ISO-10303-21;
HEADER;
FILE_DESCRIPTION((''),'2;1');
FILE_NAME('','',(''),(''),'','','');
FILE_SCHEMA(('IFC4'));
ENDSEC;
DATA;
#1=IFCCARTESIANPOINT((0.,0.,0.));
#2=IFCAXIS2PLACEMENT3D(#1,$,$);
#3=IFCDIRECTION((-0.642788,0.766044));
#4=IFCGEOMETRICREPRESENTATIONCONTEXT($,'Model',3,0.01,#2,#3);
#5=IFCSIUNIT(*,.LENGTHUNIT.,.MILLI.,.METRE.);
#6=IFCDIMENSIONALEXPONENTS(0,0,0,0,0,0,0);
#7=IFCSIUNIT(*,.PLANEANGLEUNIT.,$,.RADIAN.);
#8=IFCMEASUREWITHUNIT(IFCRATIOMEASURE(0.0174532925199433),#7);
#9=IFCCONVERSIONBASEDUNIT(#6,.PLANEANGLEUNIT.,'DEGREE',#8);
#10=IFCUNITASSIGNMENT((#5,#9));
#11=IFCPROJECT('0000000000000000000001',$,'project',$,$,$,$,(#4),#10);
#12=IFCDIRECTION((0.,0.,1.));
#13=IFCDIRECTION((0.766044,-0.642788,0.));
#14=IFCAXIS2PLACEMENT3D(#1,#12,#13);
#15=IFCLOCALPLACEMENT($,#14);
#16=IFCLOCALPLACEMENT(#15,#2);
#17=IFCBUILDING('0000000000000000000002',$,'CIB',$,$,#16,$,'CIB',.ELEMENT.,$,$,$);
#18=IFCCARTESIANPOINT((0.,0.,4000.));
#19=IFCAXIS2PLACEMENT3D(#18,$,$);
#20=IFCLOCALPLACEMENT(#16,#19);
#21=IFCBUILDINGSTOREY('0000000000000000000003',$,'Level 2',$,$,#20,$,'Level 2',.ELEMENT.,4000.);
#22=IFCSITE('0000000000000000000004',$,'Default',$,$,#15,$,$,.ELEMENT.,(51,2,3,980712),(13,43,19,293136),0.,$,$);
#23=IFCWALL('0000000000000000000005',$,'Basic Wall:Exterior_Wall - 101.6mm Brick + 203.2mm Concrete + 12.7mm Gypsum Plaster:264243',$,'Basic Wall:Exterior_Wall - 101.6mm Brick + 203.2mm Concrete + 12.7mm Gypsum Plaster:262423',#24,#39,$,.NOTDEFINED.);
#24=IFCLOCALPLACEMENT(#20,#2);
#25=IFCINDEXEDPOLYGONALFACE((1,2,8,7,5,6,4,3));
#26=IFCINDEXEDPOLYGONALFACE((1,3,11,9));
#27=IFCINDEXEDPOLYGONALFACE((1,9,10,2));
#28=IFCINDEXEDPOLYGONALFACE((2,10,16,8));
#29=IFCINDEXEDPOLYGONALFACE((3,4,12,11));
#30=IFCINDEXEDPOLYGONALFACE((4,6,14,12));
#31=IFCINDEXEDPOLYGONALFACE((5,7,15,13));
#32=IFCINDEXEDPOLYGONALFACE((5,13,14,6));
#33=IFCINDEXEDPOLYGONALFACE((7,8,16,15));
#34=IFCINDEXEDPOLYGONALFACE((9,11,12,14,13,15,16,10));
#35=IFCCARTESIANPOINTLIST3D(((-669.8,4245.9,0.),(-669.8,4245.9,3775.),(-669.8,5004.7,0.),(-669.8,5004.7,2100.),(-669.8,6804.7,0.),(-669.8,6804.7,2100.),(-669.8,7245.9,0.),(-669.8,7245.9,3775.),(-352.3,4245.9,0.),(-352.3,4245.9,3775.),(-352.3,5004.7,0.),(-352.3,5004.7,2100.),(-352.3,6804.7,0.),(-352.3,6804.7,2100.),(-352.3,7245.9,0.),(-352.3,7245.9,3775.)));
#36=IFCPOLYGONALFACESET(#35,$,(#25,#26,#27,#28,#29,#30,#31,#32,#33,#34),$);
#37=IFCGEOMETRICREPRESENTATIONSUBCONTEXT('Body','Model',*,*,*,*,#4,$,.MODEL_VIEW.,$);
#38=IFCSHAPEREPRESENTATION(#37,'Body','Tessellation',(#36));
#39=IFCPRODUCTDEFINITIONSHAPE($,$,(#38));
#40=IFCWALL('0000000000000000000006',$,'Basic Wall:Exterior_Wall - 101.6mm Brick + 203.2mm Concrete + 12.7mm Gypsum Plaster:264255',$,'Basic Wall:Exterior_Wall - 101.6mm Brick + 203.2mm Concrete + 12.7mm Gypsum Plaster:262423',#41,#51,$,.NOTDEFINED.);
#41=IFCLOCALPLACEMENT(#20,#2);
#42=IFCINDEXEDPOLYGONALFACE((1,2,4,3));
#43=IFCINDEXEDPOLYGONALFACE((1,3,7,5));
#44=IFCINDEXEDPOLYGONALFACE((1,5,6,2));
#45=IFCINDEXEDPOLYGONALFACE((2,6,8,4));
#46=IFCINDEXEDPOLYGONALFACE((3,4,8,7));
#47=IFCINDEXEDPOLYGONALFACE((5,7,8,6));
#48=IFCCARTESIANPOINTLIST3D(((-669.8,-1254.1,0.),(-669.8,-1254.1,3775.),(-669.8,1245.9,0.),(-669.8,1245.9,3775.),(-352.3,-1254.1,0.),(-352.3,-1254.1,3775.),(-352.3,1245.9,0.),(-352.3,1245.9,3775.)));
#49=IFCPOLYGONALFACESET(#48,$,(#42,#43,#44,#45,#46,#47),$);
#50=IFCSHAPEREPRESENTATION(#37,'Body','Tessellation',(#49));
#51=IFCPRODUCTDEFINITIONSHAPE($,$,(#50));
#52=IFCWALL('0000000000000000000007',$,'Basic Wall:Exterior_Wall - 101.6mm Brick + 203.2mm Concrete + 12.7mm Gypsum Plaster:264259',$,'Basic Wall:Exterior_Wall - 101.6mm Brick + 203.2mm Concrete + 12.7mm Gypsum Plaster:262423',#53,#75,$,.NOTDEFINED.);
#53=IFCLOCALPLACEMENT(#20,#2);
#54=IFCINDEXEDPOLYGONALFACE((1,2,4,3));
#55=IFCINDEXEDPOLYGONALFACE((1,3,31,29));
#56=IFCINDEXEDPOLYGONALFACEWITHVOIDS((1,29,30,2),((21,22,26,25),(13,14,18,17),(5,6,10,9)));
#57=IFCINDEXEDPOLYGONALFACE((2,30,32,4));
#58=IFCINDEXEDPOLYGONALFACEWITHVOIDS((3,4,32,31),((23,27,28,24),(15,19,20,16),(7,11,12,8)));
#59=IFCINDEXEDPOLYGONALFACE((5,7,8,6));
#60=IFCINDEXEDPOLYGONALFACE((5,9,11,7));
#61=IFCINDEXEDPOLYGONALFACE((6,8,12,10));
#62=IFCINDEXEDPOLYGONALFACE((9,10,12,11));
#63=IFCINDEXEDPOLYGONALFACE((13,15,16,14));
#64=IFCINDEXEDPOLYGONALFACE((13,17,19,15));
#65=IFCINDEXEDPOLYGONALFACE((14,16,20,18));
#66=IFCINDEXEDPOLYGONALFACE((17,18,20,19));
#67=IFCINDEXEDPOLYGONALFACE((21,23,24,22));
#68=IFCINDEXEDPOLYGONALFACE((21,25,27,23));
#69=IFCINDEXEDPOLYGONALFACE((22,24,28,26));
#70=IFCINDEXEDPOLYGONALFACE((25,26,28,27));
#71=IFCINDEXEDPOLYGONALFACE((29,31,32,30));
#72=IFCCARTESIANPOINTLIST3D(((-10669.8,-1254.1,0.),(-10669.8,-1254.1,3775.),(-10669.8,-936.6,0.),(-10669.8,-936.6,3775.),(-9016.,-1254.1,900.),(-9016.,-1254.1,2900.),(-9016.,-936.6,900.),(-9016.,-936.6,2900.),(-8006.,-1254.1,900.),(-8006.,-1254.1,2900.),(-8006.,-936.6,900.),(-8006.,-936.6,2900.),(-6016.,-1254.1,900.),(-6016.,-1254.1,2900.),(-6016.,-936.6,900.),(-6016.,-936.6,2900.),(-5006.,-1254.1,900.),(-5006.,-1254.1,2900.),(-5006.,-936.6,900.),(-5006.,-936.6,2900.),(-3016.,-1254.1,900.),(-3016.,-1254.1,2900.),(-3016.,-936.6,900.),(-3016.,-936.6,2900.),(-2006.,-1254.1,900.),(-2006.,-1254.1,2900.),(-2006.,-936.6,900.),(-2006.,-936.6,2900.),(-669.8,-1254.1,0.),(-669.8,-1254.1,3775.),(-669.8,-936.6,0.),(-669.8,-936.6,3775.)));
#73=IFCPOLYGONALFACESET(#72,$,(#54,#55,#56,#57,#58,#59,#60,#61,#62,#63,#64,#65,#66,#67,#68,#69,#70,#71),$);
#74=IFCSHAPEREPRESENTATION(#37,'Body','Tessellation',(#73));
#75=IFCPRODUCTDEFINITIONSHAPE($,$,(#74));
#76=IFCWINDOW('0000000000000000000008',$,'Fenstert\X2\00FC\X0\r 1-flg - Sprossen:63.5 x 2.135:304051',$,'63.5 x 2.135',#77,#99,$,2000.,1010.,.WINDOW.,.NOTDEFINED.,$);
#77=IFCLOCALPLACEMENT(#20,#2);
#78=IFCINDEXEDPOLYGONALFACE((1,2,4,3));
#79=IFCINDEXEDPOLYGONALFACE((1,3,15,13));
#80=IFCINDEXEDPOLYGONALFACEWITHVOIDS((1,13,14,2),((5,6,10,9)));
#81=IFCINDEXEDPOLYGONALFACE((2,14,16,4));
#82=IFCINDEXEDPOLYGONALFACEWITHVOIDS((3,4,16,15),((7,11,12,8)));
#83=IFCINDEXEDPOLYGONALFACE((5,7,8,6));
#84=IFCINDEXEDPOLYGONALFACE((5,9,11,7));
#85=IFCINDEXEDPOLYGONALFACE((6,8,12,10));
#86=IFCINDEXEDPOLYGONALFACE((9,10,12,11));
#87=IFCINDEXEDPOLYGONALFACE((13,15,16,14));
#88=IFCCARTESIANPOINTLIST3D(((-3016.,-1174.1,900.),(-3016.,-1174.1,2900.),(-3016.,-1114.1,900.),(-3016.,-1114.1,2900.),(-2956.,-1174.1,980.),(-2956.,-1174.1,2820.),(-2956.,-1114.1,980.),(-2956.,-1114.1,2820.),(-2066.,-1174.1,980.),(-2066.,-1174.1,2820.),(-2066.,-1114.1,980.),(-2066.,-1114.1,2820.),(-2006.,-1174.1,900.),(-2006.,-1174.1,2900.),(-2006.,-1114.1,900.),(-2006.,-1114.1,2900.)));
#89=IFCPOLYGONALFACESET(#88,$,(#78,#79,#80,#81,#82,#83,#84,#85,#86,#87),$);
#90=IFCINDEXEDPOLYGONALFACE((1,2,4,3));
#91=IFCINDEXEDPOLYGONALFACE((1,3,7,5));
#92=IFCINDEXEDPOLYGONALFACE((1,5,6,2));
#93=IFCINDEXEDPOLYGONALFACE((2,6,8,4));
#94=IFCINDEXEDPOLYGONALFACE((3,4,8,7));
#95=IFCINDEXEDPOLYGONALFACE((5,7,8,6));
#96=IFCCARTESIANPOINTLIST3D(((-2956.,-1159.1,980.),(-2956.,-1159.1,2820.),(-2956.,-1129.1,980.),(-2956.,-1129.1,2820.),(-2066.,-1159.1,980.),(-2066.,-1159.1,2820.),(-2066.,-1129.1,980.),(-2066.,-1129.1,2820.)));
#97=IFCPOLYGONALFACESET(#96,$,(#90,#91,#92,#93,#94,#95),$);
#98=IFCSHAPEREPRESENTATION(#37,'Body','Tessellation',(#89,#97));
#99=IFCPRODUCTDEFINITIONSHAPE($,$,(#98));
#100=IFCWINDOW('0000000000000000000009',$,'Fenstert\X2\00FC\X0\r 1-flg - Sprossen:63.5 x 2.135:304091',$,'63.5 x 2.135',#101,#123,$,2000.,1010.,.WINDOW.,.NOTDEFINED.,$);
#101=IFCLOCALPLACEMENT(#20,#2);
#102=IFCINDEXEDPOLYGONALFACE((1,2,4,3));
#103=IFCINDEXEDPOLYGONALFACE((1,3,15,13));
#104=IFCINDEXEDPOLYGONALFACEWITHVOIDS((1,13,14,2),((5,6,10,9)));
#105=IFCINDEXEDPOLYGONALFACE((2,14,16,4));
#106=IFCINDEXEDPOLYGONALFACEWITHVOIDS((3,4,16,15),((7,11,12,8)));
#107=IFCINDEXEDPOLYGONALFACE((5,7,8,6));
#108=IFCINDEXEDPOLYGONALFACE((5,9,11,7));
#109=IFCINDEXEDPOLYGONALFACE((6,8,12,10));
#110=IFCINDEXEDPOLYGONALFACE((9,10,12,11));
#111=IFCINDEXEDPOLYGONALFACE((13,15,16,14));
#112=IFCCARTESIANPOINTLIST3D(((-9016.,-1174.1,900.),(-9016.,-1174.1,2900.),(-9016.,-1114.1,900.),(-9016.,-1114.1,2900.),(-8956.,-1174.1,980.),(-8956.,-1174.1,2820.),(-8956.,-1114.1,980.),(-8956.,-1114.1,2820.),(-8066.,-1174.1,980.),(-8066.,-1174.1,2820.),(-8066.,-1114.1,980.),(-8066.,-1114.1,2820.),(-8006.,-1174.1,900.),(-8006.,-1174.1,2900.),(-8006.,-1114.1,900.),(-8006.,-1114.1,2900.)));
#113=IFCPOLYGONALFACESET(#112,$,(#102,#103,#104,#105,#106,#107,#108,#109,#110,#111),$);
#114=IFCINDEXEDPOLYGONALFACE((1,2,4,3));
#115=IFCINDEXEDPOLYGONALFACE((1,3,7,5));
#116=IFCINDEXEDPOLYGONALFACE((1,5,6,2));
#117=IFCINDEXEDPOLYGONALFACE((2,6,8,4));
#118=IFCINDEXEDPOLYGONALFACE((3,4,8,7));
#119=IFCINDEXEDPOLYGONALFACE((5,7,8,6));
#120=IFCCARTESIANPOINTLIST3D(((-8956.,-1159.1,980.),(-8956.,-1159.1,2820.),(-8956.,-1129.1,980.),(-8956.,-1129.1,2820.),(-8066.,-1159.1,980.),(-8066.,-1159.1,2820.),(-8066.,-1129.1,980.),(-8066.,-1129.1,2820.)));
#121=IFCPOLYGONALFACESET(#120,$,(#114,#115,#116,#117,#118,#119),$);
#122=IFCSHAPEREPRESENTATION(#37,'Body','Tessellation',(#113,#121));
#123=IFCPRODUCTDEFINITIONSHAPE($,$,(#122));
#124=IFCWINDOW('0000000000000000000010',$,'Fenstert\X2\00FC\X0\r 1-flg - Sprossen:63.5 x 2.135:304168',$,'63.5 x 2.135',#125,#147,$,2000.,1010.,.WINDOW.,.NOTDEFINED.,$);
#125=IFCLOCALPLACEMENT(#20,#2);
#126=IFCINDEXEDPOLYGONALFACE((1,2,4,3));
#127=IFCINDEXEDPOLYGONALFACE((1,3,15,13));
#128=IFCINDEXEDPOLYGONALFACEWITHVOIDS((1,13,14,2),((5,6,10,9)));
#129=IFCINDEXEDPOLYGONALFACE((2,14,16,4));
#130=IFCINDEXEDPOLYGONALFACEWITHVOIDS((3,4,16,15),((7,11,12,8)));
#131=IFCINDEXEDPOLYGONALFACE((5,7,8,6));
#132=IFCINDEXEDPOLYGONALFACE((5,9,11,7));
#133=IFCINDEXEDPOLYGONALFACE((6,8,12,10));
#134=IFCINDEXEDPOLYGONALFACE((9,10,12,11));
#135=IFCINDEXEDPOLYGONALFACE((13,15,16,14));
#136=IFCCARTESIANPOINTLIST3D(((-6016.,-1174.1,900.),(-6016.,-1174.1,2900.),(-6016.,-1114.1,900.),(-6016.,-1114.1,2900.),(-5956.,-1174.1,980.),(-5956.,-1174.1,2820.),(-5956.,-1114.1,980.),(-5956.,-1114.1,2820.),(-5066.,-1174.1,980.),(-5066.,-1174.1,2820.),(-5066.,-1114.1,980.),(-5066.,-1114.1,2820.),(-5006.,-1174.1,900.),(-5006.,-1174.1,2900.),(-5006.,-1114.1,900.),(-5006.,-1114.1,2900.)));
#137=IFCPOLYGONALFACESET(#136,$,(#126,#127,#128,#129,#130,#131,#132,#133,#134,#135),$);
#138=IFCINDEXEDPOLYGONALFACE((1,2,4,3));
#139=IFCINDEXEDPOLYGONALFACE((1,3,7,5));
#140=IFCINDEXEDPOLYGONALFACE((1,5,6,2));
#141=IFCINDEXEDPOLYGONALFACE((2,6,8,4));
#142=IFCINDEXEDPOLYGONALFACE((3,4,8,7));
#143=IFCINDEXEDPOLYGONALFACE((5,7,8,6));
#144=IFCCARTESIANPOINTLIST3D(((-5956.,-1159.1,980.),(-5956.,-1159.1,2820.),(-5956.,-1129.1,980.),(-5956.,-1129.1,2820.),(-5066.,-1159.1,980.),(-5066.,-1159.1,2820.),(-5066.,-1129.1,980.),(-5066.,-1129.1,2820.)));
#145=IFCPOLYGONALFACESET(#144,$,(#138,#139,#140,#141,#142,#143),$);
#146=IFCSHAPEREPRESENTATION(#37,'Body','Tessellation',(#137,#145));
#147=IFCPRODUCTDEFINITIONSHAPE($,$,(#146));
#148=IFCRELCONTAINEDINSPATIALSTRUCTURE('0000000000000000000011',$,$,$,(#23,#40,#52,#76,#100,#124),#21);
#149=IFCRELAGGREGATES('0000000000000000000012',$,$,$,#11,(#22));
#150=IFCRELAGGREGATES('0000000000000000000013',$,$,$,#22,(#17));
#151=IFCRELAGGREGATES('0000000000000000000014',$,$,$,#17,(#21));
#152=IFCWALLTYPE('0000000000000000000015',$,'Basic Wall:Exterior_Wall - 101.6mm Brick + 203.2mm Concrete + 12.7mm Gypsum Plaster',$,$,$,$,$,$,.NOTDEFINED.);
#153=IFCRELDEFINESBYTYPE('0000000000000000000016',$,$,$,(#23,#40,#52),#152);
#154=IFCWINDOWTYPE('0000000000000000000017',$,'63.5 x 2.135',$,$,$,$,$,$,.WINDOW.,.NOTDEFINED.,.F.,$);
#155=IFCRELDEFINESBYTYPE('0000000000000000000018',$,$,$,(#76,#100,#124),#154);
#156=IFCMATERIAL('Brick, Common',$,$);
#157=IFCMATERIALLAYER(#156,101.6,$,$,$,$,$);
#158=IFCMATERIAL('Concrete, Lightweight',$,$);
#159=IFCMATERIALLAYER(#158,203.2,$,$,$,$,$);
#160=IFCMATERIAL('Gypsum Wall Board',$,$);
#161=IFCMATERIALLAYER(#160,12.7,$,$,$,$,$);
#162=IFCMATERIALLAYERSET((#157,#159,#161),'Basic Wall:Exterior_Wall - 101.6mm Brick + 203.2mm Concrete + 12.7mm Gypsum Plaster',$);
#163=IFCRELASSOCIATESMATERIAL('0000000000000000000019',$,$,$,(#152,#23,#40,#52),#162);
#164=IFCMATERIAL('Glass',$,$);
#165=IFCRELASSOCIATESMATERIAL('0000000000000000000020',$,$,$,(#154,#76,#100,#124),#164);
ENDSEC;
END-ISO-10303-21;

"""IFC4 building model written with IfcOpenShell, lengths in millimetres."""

from ifc_helpers import new_model, entity, si_unit, converted_unit, direction, frame, frame_2d, origin, origin_2d_with_axis, place, context, subcontext, project, spatial, polyline, rectangle, outline, extrude, clip, bounded_halfspace, source, transform, mapped, material, layer, layer_set, layer_usage, type_object, type_shapes, element, fill, save


model = new_model("IFC4")

# Units and contexts
model_context = context("Model", 3, precision=0.01, world=origin(), true_north=direction((-0.642788, 0.766044)))
body_context = subcontext(model_context, "Body", "Model", "MODEL_VIEW")
ifc_project = project(units=[si_unit("LENGTHUNIT", "METRE", prefix="MILLI"), converted_unit("PLANEANGLEUNIT", "DEGREE", entity("IfcRatioMeasure", 0.0174532925199433), si_unit("PLANEANGLEUNIT", "RADIAN"), dimensions=[0, 0, 0, 0, 0, 0, 0])], contexts=[model_context])

# Site, building, storey
site_placement = place(None, frame((0.0, 0.0, 0.0), z_axis=(0.0, 0.0, 1.0), x_axis=(0.766044, -0.642788, 0.0)))
site = spatial("IfcSite", under=ifc_project, at=site_placement, Name="Default", CompositionType="ELEMENT", RefLatitude=(51, 2, 3, 980712), RefLongitude=(13, 43, 19, 293136), RefElevation=0.0)
building_placement = place(site_placement, origin())
building = spatial("IfcBuilding", under=site, at=building_placement, Name="CIB", LongName="CIB", CompositionType="ELEMENT")
storey_placement = place(building_placement, frame((0.0, 0.0, 4000.0)))
storey = spatial("IfcBuildingStorey", under=building, at=storey_placement, Name="Level 2", LongName="Level 2", CompositionType="ELEMENT", Elevation=4000.0)

# Wall, opening
ifc_material_1 = material(Name="Brick, Common")
ifc_layer_1 = layer(ifc_material_1, 101.6)
ifc_material_2 = material(Name="Concrete, Lightweight")
ifc_layer_2 = layer(ifc_material_2, 203.2)
ifc_material_3 = material(Name="Gypsum Wall Board")
ifc_layer_3 = layer(ifc_material_3, 12.7)
ifc_layer_set_1 = layer_set([ifc_layer_1, ifc_layer_2, ifc_layer_3], Name="Basic Wall:Exterior_Wall - 101.6mm Brick + 203.2mm Concrete + 12.7mm Gypsum Plaster")
ifc_layer_usage_1 = layer_usage(ifc_layer_set_1, "AXIS2", "POSITIVE", -158.8)
wall_type_1 = type_object("IfcWallType", Name="Basic Wall:Exterior_Wall - 101.6mm Brick + 203.2mm Concrete + 12.7mm Gypsum Plaster", PredefinedType="NOTDEFINED", material=ifc_layer_set_1)
wall_1_placement = place(storey_placement, frame((-511.0, 4245.9, 0.0), z_axis=(0.0, 0.0, 1.0), x_axis=(0.0, 1.0, 0.0)))
wall_1 = element("IfcWall", 1, at=wall_1_placement, inside=storey, type_object=wall_type_1, material=ifc_layer_usage_1, Name="Basic Wall:Exterior_Wall - 101.6mm Brick + 203.2mm Concrete + 12.7mm Gypsum Plaster:264243", ObjectType="Basic Wall:Exterior_Wall - 101.6mm Brick + 203.2mm Concrete + 12.7mm Gypsum Plaster:262423", PredefinedType="NOTDEFINED", context=body_context, shape_type="Clipping", body=[
    clip(extrude(rectangle(XDim=3000.0, YDim=317.5, at=frame_2d((1500.0, 0.0), x_axis=(-1.0, 0.0))), origin(), (0.0, 0.0, 1.0), 3775.0), bounded_halfspace(frame((3000.0, 158.8, 3775.0), z_axis=(0.0, 0.0, -1.0), x_axis=(1.0, 0.0, 0.0)), True, frame((3000.0, 158.8, 3775.0)), polyline([(0.0, 0.0), (-3000.0, 0.0), (-3000.0, -317.5), (-2682.5, -317.5), (0.0, -317.5), (0.0, 0.0)]))),
])
opening_1_placement = place(wall_1_placement, frame((758.7, -158.8, 0.0)))
element("IfcOpeningElement", 2, at=opening_1_placement, cuts=wall_1, ObjectType="Opening", PredefinedType="OPENING", context=body_context, shape_type="SweptSolid", body=[
    extrude(rectangle(XDim=2100.0, YDim=1800.0, at=frame_2d((1050.0, 900.0), x_axis=(1.0, 0.0))), frame((0.0, 0.0, 0.0), z_axis=(0.0, 1.0, 0.0), x_axis=(0.0, 0.0, 1.0)), (0.0, 0.0, 1.0), 317.5),
])

# Wall
ifc_layer_usage_2 = layer_usage(ifc_layer_set_1, "AXIS2", "NEGATIVE", 158.8)
wall_2_placement = place(storey_placement, frame((-511.0, 1245.9, 0.0), z_axis=(0.0, 0.0, 1.0), x_axis=(0.0, -1.0, 0.0)))
element("IfcWall", 3, at=wall_2_placement, inside=storey, type_object=wall_type_1, material=ifc_layer_usage_2, Name="Basic Wall:Exterior_Wall - 101.6mm Brick + 203.2mm Concrete + 12.7mm Gypsum Plaster:264255", ObjectType="Basic Wall:Exterior_Wall - 101.6mm Brick + 203.2mm Concrete + 12.7mm Gypsum Plaster:262423", PredefinedType="NOTDEFINED", context=body_context, shape_type="Clipping", body=[
    clip(extrude(rectangle(XDim=2500.0, YDim=317.5, at=frame_2d((1250.0, 0.0), x_axis=(-1.0, 0.0))), origin(), (0.0, 0.0, 1.0), 3775.0), bounded_halfspace(frame((0.0, -158.8, 3775.0), z_axis=(0.0, 0.0, -1.0), x_axis=(-1.0, 0.0, 0.0)), True, frame((0.0, -158.8, 3775.0)), polyline([(0.0, 0.0), (2182.5, 0.0), (2500.0, 0.0), (2500.0, 317.5), (0.0, 317.5), (0.0, 0.0)]))),
])

# Wall, openings, windows
ifc_layer_usage_3 = layer_usage(ifc_layer_set_1, "AXIS2", "NEGATIVE", 158.8)
wall_3_placement = place(storey_placement, frame((-669.8, -1095.3, 0.0), z_axis=(0.0, 0.0, 1.0), x_axis=(-1.0, 0.0, 0.0)))
wall_3 = element("IfcWall", 4, at=wall_3_placement, inside=storey, type_object=wall_type_1, material=ifc_layer_usage_3, Name="Basic Wall:Exterior_Wall - 101.6mm Brick + 203.2mm Concrete + 12.7mm Gypsum Plaster:264259", ObjectType="Basic Wall:Exterior_Wall - 101.6mm Brick + 203.2mm Concrete + 12.7mm Gypsum Plaster:262423", PredefinedType="NOTDEFINED", context=body_context, shape_type="Clipping", body=[
    clip(extrude(rectangle(XDim=10000.0, YDim=317.5, at=frame_2d((5000.0, 0.0), x_axis=(-1.0, 0.0))), origin(), (0.0, 0.0, 1.0), 3775.0), bounded_halfspace(frame((0.0, -158.8, 3775.0), z_axis=(0.0, 0.0, -1.0), x_axis=(0.0, -1.0, 0.0)), True, frame((0.0, -158.8, 3775.0)), polyline([(0.0, 0.0), (9682.5, 0.0), (10000.0, 0.0), (10000.0, 317.5), (0.0, 317.5), (0.0, 0.0)]))),
])
opening_2_placement = place(wall_3_placement, frame((2346.2, 158.7, 900.0)))
opening_2 = element("IfcOpeningElement", 5, at=opening_2_placement, cuts=wall_3, ObjectType="Opening", PredefinedType="OPENING", context=body_context, shape_type="SweptSolid", body=[
    extrude(rectangle(XDim=2000.0, YDim=1010.0, at=frame_2d((1000.0, 505.0), x_axis=(1.0, 0.0))), frame((0.0, 0.0, 0.0), z_axis=(0.0, -1.0, 0.0), x_axis=(0.0, 0.0, 1.0)), (0.0, 0.0, 1.0), 317.5),
])
opening_3_placement = place(wall_3_placement, frame((8346.2, 158.7, 900.0)))
opening_3 = element("IfcOpeningElement", 6, at=opening_3_placement, cuts=wall_3, ObjectType="Opening", PredefinedType="OPENING", context=body_context, shape_type="SweptSolid", body=[
    extrude(rectangle(XDim=2000.0, YDim=1010.0, at=frame_2d((1000.0, 505.0), x_axis=(1.0, 0.0))), frame((0.0, 0.0, 0.0), z_axis=(0.0, -1.0, 0.0), x_axis=(0.0, 0.0, 1.0)), (0.0, 0.0, 1.0), 317.5),
])
opening_4_placement = place(wall_3_placement, frame((5346.2, 158.7, 900.0)))
opening_4 = element("IfcOpeningElement", 7, at=opening_4_placement, cuts=wall_3, ObjectType="Opening", PredefinedType="OPENING", context=body_context, shape_type="SweptSolid", body=[
    extrude(rectangle(XDim=2000.0, YDim=1010.0, at=frame_2d((1000.0, 505.0), x_axis=(1.0, 0.0))), frame((0.0, 0.0, 0.0), z_axis=(0.0, -1.0, 0.0), x_axis=(0.0, 0.0, 1.0)), (0.0, 0.0, 1.0), 317.5),
])
ifc_material_4 = material(Name="Glass")
window_type = type_object("IfcWindowType", Name="63.5 x 2.135", ParameterTakesPrecedence=False, PartitioningType="NOTDEFINED", PredefinedType="WINDOW", material=ifc_material_4)
shared_shape_1 = source(origin(), body_context, "Body", "SweptSolid", [
    extrude(outline(polyline([(-1000.0, -505.0), (1000.0, -505.0), (1000.0, 505.0), (-1000.0, 505.0), (-1000.0, -505.0)]), holes=[polyline([(-920.0, -445.0), (-920.0, 445.0), (920.0, 445.0), (920.0, -445.0), (-920.0, -445.0)])]), frame((505.0, 177.5, 1000.0), z_axis=(0.0, 1.0, 0.0), x_axis=(0.0, 0.0, -1.0)), (0.0, 0.0, 1.0), 60.0),
    extrude(rectangle(XDim=30.0, YDim=890.0, at=origin_2d_with_axis()), frame((505.0, 207.5, 80.0), z_axis=(0.0, 0.0, 1.0), x_axis=(0.0, 1.0, 0.0)), (0.0, 0.0, 1.0), 1840.0),
])
type_shapes(window_type, [shared_shape_1])
window_1_placement = place(opening_2_placement, frame((-1010.0, -317.5, 0.0)))
window_1 = element("IfcWindow", 8, at=window_1_placement, inside=storey, type_object=window_type, material=ifc_material_4, Name="Fenstertür 1-flg - Sprossen:63.5 x 2.135:304051", ObjectType="63.5 x 2.135", OverallHeight=2000.0, OverallWidth=1010.0, PartitioningType="NOTDEFINED", PredefinedType="WINDOW", context=body_context, shape_type="MappedRepresentation", body=[
    mapped(shared_shape_1, transform((0.0, 0.0, 0.0), scale=1.0)),
])
fill(opening_2, window_1)
window_2_placement = place(opening_3_placement, frame((-1010.0, -317.5, 0.0)))
window_2 = element("IfcWindow", 9, at=window_2_placement, inside=storey, type_object=window_type, material=ifc_material_4, Name="Fenstertür 1-flg - Sprossen:63.5 x 2.135:304091", ObjectType="63.5 x 2.135", OverallHeight=2000.0, OverallWidth=1010.0, PartitioningType="NOTDEFINED", PredefinedType="WINDOW", context=body_context, shape_type="MappedRepresentation", body=[
    mapped(shared_shape_1, transform((0.0, 0.0, 0.0), scale=1.0)),
])
fill(opening_3, window_2)
window_3_placement = place(opening_4_placement, frame((-1010.0, -317.5, 0.0)))
window_3 = element("IfcWindow", 10, at=window_3_placement, inside=storey, type_object=window_type, material=ifc_material_4, Name="Fenstertür 1-flg - Sprossen:63.5 x 2.135:304168", ObjectType="63.5 x 2.135", OverallHeight=2000.0, OverallWidth=1010.0, PartitioningType="NOTDEFINED", PredefinedType="WINDOW", context=body_context, shape_type="MappedRepresentation", body=[
    mapped(shared_shape_1, transform((0.0, 0.0, 0.0), scale=1.0)),
])
fill(opening_4, window_3)

save(model, "model.ifc")
